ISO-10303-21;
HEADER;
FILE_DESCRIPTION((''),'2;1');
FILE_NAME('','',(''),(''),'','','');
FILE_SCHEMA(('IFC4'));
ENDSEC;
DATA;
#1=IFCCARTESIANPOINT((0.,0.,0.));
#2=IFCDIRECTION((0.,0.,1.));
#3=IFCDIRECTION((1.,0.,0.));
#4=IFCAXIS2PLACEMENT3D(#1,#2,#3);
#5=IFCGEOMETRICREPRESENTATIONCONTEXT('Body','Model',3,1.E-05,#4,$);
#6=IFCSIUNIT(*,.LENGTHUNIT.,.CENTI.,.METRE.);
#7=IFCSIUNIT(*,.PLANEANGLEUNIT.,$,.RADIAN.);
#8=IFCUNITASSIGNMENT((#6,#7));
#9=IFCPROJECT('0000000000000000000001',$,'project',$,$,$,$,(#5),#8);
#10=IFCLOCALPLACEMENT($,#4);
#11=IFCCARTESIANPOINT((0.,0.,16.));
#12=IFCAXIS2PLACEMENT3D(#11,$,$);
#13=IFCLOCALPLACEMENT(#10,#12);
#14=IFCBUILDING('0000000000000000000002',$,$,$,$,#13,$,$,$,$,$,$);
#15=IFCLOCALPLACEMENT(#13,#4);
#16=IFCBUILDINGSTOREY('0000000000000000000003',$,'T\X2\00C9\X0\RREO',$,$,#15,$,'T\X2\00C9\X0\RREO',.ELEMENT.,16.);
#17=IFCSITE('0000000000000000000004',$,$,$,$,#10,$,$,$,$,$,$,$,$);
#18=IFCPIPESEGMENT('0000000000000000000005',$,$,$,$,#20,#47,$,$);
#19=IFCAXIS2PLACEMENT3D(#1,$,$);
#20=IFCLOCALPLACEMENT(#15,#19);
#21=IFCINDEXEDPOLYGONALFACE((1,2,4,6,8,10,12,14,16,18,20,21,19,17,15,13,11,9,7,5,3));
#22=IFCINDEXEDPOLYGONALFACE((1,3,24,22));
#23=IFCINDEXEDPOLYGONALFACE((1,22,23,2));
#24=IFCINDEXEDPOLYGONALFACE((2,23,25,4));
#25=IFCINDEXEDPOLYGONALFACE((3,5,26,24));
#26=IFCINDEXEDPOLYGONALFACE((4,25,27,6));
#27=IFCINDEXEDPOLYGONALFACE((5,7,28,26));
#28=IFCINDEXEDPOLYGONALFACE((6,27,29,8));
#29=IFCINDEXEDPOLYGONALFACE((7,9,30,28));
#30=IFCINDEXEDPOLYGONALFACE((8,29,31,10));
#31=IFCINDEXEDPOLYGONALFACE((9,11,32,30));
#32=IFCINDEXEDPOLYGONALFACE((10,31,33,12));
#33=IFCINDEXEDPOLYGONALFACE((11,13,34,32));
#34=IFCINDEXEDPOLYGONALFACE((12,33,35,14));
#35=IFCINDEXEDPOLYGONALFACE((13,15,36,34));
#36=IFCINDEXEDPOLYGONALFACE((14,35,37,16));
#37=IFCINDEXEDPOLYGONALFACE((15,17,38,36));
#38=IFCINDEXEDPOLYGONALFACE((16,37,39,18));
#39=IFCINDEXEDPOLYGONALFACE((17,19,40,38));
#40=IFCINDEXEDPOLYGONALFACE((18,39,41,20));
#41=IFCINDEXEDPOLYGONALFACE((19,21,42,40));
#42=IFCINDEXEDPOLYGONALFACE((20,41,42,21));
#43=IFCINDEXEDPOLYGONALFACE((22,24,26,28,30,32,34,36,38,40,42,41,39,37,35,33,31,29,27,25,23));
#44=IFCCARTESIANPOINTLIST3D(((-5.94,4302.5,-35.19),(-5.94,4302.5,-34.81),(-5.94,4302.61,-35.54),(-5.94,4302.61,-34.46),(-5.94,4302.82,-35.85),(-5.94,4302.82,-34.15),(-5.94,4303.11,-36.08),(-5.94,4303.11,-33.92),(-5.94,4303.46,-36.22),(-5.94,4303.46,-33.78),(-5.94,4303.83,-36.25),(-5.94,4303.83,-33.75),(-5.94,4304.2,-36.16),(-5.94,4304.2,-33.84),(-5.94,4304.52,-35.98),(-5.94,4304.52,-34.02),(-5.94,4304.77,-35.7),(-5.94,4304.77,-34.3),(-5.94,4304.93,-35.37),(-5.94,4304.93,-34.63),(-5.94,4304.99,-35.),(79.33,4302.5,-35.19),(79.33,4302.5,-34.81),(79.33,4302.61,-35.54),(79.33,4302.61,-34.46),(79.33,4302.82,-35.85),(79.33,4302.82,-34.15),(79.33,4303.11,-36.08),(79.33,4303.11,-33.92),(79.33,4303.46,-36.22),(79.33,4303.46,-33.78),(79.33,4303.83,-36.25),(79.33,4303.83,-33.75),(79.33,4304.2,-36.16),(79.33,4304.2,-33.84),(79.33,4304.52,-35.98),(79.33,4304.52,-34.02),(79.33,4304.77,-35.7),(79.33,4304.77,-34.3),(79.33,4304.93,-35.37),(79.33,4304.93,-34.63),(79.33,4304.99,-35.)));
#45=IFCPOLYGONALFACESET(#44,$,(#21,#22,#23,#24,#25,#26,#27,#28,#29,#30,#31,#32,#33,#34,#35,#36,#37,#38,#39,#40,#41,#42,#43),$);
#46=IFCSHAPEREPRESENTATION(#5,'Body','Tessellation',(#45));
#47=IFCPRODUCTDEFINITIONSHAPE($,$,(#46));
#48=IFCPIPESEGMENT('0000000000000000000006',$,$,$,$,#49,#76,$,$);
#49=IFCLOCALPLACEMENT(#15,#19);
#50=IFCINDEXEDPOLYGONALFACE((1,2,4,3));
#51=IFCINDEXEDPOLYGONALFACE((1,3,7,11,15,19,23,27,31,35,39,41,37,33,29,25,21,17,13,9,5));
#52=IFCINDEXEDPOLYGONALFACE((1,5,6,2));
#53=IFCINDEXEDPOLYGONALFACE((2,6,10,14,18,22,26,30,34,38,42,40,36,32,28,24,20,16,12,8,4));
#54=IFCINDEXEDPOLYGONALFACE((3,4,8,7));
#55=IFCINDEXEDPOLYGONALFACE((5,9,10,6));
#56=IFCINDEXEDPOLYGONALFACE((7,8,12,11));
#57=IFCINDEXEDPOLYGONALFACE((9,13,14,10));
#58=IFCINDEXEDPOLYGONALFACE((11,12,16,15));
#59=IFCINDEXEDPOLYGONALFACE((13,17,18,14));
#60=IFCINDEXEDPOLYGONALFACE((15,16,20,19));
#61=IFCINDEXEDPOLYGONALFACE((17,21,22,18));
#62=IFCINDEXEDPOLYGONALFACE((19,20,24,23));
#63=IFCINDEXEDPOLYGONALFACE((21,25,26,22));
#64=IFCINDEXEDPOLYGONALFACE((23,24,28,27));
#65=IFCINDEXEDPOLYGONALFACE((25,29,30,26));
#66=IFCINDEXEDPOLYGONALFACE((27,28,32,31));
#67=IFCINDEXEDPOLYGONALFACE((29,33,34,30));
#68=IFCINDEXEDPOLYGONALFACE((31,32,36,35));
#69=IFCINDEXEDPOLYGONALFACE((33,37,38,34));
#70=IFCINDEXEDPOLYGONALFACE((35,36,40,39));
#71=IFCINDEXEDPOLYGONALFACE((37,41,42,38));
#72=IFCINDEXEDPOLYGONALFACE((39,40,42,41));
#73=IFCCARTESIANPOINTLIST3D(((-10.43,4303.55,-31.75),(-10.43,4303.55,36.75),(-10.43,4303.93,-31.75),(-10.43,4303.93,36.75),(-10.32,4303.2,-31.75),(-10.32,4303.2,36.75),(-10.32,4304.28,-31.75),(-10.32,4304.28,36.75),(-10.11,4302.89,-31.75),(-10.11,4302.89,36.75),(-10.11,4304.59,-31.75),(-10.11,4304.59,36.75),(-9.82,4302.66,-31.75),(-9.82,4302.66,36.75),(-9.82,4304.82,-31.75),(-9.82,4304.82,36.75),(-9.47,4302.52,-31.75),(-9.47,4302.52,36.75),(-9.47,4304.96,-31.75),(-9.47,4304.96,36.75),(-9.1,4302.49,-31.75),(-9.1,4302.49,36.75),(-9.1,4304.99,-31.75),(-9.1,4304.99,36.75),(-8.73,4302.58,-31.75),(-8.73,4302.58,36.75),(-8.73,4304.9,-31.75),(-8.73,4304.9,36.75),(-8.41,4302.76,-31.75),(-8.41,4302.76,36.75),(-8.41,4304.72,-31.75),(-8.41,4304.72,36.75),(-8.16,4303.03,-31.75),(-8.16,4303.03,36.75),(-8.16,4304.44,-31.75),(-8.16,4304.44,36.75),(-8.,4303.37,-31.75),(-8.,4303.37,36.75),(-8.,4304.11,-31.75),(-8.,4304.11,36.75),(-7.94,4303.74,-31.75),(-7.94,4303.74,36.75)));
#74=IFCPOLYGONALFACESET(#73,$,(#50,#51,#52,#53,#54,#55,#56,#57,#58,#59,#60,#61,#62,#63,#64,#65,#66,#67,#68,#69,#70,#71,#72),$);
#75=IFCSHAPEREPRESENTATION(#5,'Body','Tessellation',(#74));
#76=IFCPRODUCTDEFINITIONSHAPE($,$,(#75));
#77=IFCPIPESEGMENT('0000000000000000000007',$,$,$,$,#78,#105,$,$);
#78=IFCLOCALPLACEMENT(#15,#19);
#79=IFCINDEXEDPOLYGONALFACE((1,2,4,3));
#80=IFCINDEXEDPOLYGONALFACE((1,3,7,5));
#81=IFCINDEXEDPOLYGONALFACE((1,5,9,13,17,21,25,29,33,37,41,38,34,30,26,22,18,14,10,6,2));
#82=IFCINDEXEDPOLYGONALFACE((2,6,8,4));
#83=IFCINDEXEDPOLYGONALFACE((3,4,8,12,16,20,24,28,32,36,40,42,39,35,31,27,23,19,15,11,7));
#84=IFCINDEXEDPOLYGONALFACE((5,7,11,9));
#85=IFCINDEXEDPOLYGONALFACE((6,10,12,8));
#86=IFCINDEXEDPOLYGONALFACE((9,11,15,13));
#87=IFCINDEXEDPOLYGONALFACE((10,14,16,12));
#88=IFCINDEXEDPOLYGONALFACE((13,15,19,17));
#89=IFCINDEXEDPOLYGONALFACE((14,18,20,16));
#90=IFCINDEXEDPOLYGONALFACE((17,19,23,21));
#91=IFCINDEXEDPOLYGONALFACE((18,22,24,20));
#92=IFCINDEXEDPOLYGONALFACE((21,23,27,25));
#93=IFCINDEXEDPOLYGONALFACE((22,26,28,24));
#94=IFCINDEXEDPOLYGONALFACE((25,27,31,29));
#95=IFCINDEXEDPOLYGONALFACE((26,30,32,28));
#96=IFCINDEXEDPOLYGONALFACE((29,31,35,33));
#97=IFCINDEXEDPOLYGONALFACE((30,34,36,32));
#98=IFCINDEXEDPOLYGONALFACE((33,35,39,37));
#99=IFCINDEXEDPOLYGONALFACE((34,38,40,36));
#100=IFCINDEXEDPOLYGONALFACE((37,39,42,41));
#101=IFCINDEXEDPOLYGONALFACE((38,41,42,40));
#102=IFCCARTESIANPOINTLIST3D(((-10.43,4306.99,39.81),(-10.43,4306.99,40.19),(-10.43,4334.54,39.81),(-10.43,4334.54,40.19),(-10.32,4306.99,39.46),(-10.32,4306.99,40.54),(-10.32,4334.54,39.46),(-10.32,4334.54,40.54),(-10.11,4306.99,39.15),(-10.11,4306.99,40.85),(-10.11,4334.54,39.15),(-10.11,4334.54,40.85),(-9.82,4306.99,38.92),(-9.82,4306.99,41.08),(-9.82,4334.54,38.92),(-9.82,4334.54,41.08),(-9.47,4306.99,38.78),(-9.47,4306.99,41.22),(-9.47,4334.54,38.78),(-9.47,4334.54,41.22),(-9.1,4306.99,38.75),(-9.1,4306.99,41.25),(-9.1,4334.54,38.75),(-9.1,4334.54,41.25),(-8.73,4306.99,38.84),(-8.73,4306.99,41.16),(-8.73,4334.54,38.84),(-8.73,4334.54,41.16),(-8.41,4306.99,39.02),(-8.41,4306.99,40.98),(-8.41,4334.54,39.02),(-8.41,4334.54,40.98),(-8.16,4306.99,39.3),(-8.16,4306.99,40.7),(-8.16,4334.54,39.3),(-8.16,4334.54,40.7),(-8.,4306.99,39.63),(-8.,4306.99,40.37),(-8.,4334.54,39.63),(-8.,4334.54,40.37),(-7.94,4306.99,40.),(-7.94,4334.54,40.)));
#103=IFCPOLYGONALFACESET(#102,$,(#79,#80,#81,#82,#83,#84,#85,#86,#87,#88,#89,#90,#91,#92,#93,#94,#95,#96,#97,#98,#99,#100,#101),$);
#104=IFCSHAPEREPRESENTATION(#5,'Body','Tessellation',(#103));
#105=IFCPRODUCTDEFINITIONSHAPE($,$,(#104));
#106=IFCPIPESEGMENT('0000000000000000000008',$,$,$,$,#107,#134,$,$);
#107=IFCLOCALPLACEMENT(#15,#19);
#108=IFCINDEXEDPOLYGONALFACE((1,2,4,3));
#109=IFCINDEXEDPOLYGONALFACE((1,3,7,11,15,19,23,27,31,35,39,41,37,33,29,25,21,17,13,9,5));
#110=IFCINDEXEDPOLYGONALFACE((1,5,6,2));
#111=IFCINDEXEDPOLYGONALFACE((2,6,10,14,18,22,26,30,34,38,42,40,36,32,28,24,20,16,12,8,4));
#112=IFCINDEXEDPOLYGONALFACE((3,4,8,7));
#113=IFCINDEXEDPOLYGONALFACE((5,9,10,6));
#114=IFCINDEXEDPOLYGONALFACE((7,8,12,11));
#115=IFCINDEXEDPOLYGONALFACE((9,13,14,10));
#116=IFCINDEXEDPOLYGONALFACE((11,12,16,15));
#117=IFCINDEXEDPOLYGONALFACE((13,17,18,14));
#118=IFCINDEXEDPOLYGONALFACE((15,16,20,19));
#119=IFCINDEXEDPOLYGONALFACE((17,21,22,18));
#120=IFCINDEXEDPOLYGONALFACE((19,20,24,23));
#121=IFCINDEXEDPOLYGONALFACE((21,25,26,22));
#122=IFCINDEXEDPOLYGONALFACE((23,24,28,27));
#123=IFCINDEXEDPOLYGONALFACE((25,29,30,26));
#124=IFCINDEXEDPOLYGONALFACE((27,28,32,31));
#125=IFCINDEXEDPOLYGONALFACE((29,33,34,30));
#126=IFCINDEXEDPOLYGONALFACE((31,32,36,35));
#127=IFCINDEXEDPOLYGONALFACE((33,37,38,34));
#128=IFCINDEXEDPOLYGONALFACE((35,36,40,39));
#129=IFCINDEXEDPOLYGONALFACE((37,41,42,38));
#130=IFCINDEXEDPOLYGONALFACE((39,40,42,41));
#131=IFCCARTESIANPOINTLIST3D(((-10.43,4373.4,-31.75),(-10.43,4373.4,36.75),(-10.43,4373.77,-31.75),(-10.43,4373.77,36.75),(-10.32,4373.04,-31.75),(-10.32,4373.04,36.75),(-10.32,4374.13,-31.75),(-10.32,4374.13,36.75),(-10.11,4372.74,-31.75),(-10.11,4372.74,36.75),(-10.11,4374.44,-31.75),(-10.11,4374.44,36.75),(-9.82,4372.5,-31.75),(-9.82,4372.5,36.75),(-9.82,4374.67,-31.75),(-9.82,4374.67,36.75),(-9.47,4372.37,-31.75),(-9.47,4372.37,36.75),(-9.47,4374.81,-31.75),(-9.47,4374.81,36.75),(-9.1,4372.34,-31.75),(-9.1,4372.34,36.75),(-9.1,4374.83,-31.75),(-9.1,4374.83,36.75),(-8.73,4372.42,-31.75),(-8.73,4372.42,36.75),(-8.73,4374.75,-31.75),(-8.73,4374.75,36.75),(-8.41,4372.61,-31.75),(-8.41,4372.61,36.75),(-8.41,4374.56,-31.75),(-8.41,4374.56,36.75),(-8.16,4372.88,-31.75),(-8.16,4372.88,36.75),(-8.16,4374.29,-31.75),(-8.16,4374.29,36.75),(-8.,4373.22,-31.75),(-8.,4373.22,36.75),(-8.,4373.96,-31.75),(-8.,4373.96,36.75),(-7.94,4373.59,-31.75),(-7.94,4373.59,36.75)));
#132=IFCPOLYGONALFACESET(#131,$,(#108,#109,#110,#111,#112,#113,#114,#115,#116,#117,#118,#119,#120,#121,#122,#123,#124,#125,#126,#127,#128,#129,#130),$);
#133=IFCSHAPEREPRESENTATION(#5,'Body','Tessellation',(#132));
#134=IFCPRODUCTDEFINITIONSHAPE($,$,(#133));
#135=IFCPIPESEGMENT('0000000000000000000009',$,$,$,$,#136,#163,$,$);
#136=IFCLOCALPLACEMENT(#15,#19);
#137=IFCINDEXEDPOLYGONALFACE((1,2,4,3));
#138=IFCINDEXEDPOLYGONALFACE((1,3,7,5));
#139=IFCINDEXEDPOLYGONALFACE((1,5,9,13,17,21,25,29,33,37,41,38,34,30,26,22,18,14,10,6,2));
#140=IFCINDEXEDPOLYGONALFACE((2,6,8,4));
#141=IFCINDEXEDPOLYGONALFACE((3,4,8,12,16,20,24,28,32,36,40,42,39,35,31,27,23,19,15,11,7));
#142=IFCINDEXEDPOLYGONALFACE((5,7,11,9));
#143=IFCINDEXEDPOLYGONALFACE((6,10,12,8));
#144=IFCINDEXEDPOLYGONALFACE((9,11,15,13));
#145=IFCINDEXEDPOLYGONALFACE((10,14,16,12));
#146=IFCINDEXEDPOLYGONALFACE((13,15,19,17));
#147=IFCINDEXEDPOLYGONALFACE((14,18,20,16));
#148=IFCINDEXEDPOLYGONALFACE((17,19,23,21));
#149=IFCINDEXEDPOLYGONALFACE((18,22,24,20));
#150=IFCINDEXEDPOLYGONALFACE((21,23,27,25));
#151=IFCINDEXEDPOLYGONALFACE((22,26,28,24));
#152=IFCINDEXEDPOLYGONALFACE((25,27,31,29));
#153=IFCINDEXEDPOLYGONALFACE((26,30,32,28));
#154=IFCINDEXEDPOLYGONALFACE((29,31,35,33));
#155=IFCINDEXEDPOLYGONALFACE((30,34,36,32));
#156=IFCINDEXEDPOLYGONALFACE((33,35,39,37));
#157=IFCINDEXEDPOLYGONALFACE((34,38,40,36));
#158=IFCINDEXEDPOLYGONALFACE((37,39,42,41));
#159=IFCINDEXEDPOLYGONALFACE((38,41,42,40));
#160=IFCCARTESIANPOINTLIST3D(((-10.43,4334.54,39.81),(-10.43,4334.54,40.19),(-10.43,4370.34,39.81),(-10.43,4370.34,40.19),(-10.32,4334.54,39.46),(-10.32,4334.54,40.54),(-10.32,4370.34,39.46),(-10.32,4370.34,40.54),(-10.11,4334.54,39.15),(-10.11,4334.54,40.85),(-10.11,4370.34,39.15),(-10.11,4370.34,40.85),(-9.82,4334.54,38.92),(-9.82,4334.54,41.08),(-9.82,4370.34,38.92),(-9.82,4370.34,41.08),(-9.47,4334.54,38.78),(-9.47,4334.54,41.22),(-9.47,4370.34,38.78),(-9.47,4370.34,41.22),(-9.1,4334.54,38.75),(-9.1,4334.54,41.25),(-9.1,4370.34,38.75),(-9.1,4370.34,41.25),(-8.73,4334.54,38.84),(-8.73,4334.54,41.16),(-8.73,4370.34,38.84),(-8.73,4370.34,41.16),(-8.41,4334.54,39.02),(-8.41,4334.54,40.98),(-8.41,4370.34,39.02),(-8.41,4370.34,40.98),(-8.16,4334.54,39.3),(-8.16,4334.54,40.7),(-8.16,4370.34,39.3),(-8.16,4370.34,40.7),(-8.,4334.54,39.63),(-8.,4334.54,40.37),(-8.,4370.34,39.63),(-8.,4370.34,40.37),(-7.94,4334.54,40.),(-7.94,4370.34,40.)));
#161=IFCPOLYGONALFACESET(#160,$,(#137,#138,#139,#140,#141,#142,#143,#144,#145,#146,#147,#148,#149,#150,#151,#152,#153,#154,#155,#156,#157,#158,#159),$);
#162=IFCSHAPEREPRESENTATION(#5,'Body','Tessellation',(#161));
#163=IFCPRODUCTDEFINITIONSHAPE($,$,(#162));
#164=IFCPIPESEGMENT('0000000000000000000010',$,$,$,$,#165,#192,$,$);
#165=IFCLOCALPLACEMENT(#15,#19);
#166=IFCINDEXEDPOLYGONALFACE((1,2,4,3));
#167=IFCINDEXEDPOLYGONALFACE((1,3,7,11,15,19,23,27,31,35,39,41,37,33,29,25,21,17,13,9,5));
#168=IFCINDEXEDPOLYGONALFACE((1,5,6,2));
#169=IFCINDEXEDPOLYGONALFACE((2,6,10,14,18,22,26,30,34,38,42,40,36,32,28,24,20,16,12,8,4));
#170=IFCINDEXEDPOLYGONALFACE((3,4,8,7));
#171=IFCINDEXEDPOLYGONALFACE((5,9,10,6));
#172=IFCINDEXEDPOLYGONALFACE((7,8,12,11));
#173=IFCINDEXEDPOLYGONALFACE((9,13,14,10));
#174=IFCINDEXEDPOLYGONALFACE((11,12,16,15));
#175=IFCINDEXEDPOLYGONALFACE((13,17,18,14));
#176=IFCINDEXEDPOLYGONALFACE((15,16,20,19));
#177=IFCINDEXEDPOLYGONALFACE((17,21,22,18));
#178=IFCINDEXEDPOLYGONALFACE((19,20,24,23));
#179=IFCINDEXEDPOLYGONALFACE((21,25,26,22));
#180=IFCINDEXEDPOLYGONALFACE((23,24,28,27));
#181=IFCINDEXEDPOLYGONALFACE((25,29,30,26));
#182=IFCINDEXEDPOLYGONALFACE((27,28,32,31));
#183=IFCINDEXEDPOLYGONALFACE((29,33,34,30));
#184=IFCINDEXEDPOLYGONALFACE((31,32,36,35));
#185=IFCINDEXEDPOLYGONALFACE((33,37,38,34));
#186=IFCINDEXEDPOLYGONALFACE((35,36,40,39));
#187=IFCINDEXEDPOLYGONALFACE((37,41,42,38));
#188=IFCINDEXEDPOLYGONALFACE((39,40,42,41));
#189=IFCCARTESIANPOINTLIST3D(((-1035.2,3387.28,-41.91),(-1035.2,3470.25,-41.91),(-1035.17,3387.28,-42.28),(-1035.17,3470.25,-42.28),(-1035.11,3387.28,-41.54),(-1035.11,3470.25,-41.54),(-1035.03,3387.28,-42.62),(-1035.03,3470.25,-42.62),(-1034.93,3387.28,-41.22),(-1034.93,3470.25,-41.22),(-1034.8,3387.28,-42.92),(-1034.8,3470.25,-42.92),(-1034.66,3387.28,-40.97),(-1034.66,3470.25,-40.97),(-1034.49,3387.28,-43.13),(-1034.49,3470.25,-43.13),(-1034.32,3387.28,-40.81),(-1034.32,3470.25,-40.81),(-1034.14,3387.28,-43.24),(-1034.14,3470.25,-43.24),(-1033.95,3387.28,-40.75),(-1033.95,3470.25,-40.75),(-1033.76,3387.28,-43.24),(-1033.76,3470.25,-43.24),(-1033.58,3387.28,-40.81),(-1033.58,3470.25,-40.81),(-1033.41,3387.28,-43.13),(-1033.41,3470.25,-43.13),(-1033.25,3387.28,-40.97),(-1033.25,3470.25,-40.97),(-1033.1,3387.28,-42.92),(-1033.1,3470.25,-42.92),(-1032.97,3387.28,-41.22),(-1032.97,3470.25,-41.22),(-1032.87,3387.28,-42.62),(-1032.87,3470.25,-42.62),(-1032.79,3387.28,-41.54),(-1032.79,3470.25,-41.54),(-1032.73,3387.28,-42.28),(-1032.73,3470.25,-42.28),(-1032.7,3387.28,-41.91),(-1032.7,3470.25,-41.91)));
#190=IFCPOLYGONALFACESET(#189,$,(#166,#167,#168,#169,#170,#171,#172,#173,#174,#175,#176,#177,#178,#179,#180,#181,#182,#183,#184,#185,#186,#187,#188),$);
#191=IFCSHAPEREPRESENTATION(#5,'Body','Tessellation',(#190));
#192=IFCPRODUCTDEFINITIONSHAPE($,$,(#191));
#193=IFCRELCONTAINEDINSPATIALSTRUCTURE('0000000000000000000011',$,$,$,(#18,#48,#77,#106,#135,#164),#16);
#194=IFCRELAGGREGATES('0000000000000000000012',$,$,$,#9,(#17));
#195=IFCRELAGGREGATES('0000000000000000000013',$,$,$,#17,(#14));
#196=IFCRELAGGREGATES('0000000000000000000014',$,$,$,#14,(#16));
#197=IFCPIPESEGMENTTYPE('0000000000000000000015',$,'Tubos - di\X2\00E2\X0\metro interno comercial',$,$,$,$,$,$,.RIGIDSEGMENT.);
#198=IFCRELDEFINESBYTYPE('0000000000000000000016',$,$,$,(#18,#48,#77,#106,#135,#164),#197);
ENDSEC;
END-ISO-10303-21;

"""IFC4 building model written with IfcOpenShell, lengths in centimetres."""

from ifc_helpers import new_model, si_unit, frame, origin_with_axes, origin_2d_with_axis, place, context, project, spatial, circle, extrude, type_object, element, save


model = new_model("IFC4")

# Units and contexts
model_context = context("Model", 3, precision=1e-05, world=origin_with_axes(), identifier="Body")
ifc_project = project(units=[si_unit("LENGTHUNIT", "METRE", prefix="CENTI"), si_unit("PLANEANGLEUNIT", "RADIAN")], contexts=[model_context])

# Site, building, storey
site_placement = place(None, origin_with_axes())
site = spatial("IfcSite", under=ifc_project, at=site_placement)
building_placement = place(site_placement, frame((0.0, 0.0, 16.0)))
building = spatial("IfcBuilding", under=site, at=building_placement)
storey_placement = place(building_placement, origin_with_axes())
storey = spatial("IfcBuildingStorey", under=building, at=storey_placement, Name="TÉRREO", LongName="TÉRREO", CompositionType="ELEMENT", Elevation=16.0)

# Pipe segments
pipe_segment_type = type_object("IfcPipeSegmentType", Name="Tubos - diâmetro interno comercial", PredefinedType="RIGIDSEGMENT")
pipe_segment_1_placement = place(storey_placement, frame((36.7, 4303.74, -33.75), z_axis=(0.0, 0.0, 1.0), x_axis=(1.0, 0.0, 0.0)))
element("IfcPipeSegment", 1, at=pipe_segment_1_placement, inside=storey, type_object=pipe_segment_type, context=model_context, shape_type="SolidModel", body=[
    extrude(circle(Radius=1.25, at=origin_2d_with_axis()), frame((42.64, 0.0, -1.25), z_axis=(-1.0, 0.0, 0.0), x_axis=(0.0, 1.0, 0.0)), (0.0, 0.0, 1.0), 85.27),
])
pipe_segment_2_placement = place(storey_placement, frame((-9.19, 4303.74, 36.75), z_axis=(0.0, 0.0, 1.0), x_axis=(1.0, 0.0, 0.0)))
element("IfcPipeSegment", 2, at=pipe_segment_2_placement, inside=storey, type_object=pipe_segment_type, context=model_context, shape_type="SolidModel", body=[
    extrude(circle(Radius=1.25, at=origin_2d_with_axis()), frame((0.0, 0.0, -68.5), z_axis=(0.0, 0.0, 1.0), x_axis=(1.0, 0.0, 0.0)), (0.0, 0.0, 1.0), 68.5),
])
pipe_segment_3_placement = place(storey_placement, frame((-9.19, 4320.76, 41.25), z_axis=(0.0, 0.0, 1.0), x_axis=(1.0, 0.0, 0.0)))
element("IfcPipeSegment", 3, at=pipe_segment_3_placement, inside=storey, type_object=pipe_segment_type, context=model_context, shape_type="SolidModel", body=[
    extrude(circle(Radius=1.25, at=origin_2d_with_axis()), frame((0.0, -13.77, -1.25), z_axis=(0.0, 1.0, 0.0), x_axis=(1.0, 0.0, 0.0)), (0.0, 0.0, 1.0), 27.55),
])
pipe_segment_4_placement = place(storey_placement, frame((-9.19, 4373.59, 36.75), z_axis=(0.0, 0.0, 1.0), x_axis=(1.0, 0.0, 0.0)))
element("IfcPipeSegment", 4, at=pipe_segment_4_placement, inside=storey, type_object=pipe_segment_type, context=model_context, shape_type="SolidModel", body=[
    extrude(circle(Radius=1.25, at=origin_2d_with_axis()), frame((0.0, 0.0, 0.0), z_axis=(0.0, 0.0, -1.0), x_axis=(1.0, 0.0, 0.0)), (0.0, 0.0, 1.0), 68.5),
])
pipe_segment_5_placement = place(storey_placement, frame((-9.19, 4352.44, 41.25), z_axis=(0.0, 0.0, 1.0), x_axis=(1.0, 0.0, 0.0)))
element("IfcPipeSegment", 5, at=pipe_segment_5_placement, inside=storey, type_object=pipe_segment_type, context=model_context, shape_type="SolidModel", body=[
    extrude(circle(Radius=1.25, at=origin_2d_with_axis()), frame((0.0, -17.9, -1.25), z_axis=(0.0, 1.0, 0.0), x_axis=(1.0, 0.0, 0.0)), (0.0, 0.0, 1.0), 35.8),
])
pipe_segment_6_placement = place(storey_placement, frame((-1033.95, 3428.76, -40.75), z_axis=(0.0, 0.0, 1.0), x_axis=(1.0, 0.0, 0.0)))
element("IfcPipeSegment", 6, at=pipe_segment_6_placement, inside=storey, type_object=pipe_segment_type, context=model_context, shape_type="SolidModel", body=[
    extrude(circle(Radius=1.25, at=origin_2d_with_axis()), frame((0.0, 41.49, -1.25), z_axis=(0.0, -1.0, 0.0), x_axis=(0.0, 0.0, 1.0)), (0.0, 0.0, 1.0), 82.97),
])

save(model, "model.ifc")
